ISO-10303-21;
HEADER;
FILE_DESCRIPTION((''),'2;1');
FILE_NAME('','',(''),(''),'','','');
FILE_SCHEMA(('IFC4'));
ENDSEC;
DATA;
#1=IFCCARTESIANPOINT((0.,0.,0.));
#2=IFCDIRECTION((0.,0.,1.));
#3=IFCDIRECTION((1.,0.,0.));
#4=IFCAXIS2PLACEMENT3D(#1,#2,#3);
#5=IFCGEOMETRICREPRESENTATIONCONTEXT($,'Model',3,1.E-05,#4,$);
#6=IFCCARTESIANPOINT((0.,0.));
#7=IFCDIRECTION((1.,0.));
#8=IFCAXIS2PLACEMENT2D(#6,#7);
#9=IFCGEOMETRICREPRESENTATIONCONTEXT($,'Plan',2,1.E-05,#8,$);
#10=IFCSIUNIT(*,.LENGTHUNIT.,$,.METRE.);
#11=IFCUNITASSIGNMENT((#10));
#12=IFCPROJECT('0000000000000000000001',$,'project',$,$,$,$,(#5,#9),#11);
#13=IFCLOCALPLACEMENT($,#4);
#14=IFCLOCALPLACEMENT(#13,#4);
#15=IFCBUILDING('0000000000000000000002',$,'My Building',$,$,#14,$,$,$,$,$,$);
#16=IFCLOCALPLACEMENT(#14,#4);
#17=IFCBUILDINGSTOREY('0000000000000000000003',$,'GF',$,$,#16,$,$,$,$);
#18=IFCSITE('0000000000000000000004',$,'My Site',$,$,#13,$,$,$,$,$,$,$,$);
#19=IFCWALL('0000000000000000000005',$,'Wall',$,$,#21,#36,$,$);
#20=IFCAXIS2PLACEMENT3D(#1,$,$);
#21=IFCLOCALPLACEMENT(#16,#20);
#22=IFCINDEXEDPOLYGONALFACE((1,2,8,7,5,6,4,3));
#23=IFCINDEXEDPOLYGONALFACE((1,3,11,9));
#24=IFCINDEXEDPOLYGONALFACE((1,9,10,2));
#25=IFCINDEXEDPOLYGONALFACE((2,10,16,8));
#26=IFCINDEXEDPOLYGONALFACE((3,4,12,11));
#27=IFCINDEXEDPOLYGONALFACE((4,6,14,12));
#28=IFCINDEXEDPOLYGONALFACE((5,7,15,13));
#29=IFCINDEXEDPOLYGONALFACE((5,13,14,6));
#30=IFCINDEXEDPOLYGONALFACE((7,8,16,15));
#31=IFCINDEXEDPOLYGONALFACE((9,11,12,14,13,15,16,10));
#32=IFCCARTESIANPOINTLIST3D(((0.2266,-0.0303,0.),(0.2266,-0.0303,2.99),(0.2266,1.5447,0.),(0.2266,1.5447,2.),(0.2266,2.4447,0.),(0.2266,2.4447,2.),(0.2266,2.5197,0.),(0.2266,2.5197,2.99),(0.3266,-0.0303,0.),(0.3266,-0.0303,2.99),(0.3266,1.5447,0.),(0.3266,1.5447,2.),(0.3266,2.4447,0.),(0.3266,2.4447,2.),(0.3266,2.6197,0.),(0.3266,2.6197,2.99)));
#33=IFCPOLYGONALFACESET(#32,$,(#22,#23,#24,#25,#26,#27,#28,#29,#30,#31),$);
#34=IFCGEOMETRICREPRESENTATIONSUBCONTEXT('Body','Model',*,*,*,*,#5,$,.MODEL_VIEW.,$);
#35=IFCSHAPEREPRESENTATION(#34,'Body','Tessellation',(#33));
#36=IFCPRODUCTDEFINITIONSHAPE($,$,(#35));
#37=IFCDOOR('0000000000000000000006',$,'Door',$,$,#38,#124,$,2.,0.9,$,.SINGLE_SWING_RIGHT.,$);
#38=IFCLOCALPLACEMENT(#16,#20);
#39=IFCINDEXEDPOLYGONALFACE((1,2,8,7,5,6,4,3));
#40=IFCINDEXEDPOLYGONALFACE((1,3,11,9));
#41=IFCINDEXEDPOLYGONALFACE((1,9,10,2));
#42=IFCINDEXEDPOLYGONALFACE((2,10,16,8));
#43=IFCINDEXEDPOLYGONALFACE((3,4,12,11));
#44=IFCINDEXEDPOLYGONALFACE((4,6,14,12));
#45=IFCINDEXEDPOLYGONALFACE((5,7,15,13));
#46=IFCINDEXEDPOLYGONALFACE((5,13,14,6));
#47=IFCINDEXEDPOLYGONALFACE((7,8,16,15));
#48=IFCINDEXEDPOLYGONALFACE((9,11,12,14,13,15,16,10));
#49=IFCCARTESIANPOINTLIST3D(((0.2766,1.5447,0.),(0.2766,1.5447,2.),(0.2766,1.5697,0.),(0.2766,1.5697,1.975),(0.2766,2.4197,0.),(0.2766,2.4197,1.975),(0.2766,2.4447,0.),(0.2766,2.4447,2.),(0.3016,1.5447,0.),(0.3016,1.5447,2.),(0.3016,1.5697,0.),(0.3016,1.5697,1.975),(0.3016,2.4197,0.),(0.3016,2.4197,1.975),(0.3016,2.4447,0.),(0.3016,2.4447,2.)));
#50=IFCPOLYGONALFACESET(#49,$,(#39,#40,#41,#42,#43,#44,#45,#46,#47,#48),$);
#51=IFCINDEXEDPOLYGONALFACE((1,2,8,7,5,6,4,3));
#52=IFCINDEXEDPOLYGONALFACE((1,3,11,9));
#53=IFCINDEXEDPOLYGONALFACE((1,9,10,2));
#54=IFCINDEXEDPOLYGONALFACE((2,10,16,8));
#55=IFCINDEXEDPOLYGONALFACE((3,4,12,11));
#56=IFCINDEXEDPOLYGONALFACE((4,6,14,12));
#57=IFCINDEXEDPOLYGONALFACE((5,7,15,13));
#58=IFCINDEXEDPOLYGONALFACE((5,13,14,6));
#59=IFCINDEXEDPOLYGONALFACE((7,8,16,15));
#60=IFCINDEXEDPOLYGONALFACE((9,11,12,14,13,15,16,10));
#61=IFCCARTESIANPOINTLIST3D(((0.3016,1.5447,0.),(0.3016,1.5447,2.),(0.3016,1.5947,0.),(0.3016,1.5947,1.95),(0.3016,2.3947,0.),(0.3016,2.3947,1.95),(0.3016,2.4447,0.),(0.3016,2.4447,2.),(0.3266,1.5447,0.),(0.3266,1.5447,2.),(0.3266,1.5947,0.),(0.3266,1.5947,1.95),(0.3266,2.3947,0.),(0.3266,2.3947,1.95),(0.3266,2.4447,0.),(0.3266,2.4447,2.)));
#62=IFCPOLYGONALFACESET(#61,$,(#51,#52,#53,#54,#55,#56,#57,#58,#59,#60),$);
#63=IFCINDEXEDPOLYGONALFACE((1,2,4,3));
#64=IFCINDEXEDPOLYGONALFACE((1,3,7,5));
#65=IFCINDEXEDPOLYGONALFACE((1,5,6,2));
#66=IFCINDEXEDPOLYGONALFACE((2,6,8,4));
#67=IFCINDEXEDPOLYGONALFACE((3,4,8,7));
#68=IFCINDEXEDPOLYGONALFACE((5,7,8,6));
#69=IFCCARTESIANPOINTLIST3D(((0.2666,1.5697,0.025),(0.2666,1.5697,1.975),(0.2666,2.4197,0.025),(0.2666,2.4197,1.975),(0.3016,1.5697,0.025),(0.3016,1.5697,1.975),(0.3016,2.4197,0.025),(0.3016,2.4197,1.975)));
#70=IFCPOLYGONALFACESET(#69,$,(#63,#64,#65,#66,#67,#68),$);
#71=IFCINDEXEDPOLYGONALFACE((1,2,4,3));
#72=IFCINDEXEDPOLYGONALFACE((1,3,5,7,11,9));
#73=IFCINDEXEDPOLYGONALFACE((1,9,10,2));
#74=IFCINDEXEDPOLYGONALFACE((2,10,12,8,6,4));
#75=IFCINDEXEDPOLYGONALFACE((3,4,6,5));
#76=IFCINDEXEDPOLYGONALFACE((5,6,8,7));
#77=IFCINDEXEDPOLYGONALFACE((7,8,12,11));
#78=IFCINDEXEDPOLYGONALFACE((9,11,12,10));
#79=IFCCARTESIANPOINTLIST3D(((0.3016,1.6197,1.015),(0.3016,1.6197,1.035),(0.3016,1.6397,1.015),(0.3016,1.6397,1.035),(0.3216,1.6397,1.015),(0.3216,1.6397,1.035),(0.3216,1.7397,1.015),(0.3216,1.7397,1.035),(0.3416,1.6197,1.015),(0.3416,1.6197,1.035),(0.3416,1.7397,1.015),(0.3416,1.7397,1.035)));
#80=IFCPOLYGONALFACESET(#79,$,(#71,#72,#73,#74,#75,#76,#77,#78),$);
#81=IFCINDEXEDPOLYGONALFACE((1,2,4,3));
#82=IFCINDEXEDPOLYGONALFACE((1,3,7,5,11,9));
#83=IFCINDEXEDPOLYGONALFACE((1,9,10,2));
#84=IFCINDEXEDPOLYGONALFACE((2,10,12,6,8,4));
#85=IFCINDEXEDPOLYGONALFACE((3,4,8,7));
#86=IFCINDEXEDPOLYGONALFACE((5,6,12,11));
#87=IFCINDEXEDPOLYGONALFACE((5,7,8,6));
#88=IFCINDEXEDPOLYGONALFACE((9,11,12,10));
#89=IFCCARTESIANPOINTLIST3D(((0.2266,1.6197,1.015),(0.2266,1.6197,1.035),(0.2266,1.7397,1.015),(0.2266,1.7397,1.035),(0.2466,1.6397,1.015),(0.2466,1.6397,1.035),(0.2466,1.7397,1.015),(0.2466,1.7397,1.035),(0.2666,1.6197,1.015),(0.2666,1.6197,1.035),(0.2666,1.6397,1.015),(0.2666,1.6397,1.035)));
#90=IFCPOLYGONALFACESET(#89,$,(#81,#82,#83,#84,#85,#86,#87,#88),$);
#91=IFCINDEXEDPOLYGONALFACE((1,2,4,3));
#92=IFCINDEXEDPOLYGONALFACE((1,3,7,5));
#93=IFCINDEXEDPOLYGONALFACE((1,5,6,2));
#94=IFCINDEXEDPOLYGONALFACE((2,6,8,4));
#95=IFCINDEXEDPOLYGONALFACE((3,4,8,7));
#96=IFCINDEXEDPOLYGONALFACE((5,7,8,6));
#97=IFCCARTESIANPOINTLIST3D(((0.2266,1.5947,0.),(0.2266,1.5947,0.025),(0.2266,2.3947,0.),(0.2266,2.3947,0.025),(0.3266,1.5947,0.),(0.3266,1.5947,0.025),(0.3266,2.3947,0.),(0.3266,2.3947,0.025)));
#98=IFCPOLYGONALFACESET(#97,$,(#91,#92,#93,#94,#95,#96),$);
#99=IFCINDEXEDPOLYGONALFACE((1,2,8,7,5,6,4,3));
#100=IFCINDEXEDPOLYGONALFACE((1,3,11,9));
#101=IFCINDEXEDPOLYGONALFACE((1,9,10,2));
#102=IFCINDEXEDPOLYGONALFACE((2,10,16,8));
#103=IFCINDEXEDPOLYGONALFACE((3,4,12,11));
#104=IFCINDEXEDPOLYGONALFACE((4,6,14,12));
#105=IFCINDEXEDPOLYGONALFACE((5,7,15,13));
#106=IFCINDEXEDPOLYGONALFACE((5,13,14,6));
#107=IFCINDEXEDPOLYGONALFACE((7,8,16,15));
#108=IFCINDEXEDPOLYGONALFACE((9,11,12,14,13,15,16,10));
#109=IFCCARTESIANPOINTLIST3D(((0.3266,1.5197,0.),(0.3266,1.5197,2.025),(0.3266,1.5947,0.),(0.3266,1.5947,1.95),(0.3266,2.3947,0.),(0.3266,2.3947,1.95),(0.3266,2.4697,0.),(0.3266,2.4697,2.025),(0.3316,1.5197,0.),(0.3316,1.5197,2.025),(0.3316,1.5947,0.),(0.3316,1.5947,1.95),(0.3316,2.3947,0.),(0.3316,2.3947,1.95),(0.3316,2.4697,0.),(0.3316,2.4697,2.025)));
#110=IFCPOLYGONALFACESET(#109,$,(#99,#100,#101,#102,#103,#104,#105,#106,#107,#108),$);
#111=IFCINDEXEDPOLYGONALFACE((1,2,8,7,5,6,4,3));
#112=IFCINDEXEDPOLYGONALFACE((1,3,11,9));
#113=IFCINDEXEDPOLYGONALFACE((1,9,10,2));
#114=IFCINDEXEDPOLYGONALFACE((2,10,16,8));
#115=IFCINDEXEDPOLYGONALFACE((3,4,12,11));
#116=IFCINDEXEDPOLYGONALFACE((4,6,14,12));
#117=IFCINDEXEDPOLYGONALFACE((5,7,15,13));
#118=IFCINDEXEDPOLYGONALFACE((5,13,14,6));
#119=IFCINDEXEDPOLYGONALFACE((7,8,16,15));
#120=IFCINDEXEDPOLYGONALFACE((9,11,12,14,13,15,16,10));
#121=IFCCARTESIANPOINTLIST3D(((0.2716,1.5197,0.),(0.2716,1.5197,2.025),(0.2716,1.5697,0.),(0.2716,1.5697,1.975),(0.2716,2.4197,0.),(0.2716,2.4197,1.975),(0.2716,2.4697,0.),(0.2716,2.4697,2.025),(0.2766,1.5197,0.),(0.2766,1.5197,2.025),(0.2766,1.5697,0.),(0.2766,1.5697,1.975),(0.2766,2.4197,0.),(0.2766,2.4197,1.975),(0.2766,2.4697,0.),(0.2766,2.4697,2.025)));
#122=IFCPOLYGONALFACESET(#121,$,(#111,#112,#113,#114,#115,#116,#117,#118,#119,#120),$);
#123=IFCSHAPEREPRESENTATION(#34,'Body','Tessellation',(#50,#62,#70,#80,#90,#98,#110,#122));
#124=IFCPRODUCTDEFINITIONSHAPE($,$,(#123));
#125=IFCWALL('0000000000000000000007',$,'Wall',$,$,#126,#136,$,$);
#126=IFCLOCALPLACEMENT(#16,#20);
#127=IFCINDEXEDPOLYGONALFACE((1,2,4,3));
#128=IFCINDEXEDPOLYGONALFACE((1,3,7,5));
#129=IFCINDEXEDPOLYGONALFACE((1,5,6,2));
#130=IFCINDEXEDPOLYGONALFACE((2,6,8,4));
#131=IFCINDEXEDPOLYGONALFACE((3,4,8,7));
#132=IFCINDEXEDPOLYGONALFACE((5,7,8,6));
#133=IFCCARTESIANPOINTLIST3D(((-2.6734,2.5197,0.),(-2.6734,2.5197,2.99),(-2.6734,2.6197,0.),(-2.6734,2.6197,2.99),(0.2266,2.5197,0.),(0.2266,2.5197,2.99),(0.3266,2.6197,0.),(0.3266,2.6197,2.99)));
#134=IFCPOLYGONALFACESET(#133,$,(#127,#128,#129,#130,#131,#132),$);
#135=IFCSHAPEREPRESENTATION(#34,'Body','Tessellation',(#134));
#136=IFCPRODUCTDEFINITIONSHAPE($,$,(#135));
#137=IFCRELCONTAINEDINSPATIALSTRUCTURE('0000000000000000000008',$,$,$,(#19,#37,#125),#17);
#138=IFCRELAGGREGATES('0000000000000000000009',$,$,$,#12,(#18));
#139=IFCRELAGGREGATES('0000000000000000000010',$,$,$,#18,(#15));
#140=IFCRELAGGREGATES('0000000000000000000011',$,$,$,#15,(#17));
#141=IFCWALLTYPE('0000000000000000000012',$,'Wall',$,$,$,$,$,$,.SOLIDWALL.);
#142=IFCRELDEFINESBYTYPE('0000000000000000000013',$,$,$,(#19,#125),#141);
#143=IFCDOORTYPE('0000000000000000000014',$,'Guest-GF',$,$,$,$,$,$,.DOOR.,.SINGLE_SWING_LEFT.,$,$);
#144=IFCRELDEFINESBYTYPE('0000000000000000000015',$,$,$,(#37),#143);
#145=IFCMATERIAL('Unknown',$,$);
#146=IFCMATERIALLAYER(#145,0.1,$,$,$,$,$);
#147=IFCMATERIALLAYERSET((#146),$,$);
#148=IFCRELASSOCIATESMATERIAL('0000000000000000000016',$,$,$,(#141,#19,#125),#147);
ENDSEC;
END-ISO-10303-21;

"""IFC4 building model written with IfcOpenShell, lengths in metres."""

from ifc_helpers import new_model, entity, si_unit, frame, origin_with_axes, origin_2d_with_axis, place, context, subcontext, project, spatial, line, indexed_curve, outline, extrude, shape, source, transform, mapped, material, layer, layer_set, layer_usage, type_object, type_shapes, element, fill, save


model = new_model("IFC4")

# Units and contexts
model_context = context("Model", 3, precision=1e-05, world=origin_with_axes())
plan_context = context("Plan", 2, precision=1e-05, world=origin_2d_with_axis())
body_context_1 = subcontext(model_context, "Body", "Model", "MODEL_VIEW")
body_context_2 = subcontext(plan_context, "Body", "Plan", "PLAN_VIEW")
ifc_project = project(units=[si_unit("LENGTHUNIT", "METRE")], contexts=[model_context, plan_context])

# Site, building, storey
site_placement = place(None, origin_with_axes())
site = spatial("IfcSite", under=ifc_project, at=site_placement, Name="My Site")
building_placement = place(site_placement, origin_with_axes())
building = spatial("IfcBuilding", under=site, at=building_placement, Name="My Building")
storey_placement = place(building_placement, origin_with_axes())
storey = spatial("IfcBuildingStorey", under=building, at=storey_placement, Name="GF")

# Shared definitions
ifc_material_1 = material(Name="Unknown")

# Shared definitions
ifc_layer_1 = layer(ifc_material_1, 0.1)
ifc_layer_set_1 = layer_set([ifc_layer_1])
wall_type = type_object("IfcWallType", Name="Wall", PredefinedType="SOLIDWALL", material=ifc_layer_set_1)

# Wall, opening, door
ifc_layer_usage_1 = layer_usage(ifc_layer_set_1, "AXIS2", "POSITIVE", 0.0)
wall_1_placement = place(storey_placement, frame((0.3266, -0.0303, 0.0), z_axis=(0.0, 0.0, 1.0), x_axis=(0.0, 1.0, 0.0)))
wall_1 = element("IfcWall", 1, at=wall_1_placement, inside=storey, type_object=wall_type, material=ifc_layer_usage_1, Name="Wall", context=body_context_1, shape_type="SweptSolid", body=[
    extrude(outline(indexed_curve([(0.0, 0.0), (0.0, 0.1), (2.55, 0.1), (2.65, 0.0)], segments=[line(1, 2, 3, 4, 1)])), origin_with_axes(), (0.0, 0.0, 1.0), 2.99),
])
shared_shape_1 = source(origin_with_axes(), body_context_1, "Body", "SweptSolid", [
    extrude(outline(indexed_curve([(0.0, 0.0), (0.9, 0.0), (0.9, 2.0), (0.0, 2.0)], segments=[line(1, 2, 3, 4, 1)])), frame((0.0, -0.6, 0.0), z_axis=(0.0, -1.0, 0.0), x_axis=(1.0, 0.0, 0.0)), (0.0, 0.0, -1.0), 1.2),
])
opening_1_placement = place(wall_1_placement, frame((1.575, 0.0, 0.0), z_axis=(0.0, 0.0, 1.0), x_axis=(1.0, 0.0, 0.0)))
opening_1 = element("IfcOpeningElement", 2, at=opening_1_placement, cuts=wall_1, PredefinedType="OPENING", context=body_context_1, shape_type="MappedRepresentation", body=[
    mapped(shared_shape_1, transform((0.0, 0.0, 0.0), x_axis=(1.0, 0.0, 0.0), y_axis=(0.0, 1.0, 0.0), z_axis=(0.0, 0.0, 1.0), scale=1.0)),
])
door_type_1 = type_object("IfcDoorType", Name="Guest-GF", OperationType="SINGLE_SWING_LEFT", PredefinedType="DOOR")
shared_shape_2 = source(origin_with_axes(), body_context_1, "Body", "SweptSolid", [
    extrude(outline(indexed_curve([(0.0, 0.0), (0.0, 2.0), (0.9, 2.0), (0.9, 0.0), (0.875, 0.0), (0.875, 1.975), (0.025, 1.975), (0.025, 0.0)], segments=[line(1, 2, 3, 4, 5, 6, 7, 8, 1)])), frame((0.0, 0.025, 0.0), z_axis=(0.0, -1.0, 0.0), x_axis=(1.0, 0.0, 0.0)), (0.0, 0.0, -1.0), 0.025),
    extrude(outline(indexed_curve([(0.0, 0.0), (0.0, 2.0), (0.9, 2.0), (0.9, 0.0), (0.85, 0.0), (0.85, 1.95), (0.05, 1.95), (0.05, 0.0)], segments=[line(1, 2, 3, 4, 5, 6, 7, 8, 1)])), frame((0.0, 0.0, 0.0), z_axis=(0.0, -1.0, 0.0), x_axis=(1.0, 0.0, 0.0)), (0.0, 0.0, -1.0), 0.025),
    extrude(outline(indexed_curve([(0.0, 0.0), (0.85, 0.0), (0.85, 0.035), (0.0, 0.035)], segments=[line(1, 2, 3, 4, 1)])), frame((0.025, 0.025, 0.025), z_axis=(0.0, 0.0, 1.0), x_axis=(1.0, 0.0, 0.0)), (0.0, 0.0, 1.0), 1.95),
    extrude(outline(indexed_curve([(0.0, 0.0), (0.0, -0.04), (0.12, -0.04), (0.12, -0.02), (0.02, -0.02), (0.02, 0.0)], segments=[line(1, 2, 3, 4, 5, 6, 1)])), frame((0.075, 0.025, 1.015), z_axis=(0.0, 0.0, 1.0), x_axis=(1.0, 0.0, 0.0)), (0.0, 0.0, 1.0), 0.02),
    extrude(outline(indexed_curve([(0.0, 0.0), (0.0, 0.04), (0.12, 0.04), (0.12, 0.02), (0.02, 0.02), (0.02, 0.0)], segments=[line(1, 2, 3, 4, 5, 6, 1)])), frame((0.075, 0.06, 1.015), z_axis=(0.0, 0.0, 1.0), x_axis=(1.0, 0.0, 0.0)), (0.0, 0.0, 1.0), 0.02),
    extrude(outline(indexed_curve([(0.0, 0.0), (0.8, 0.0), (0.8, 0.1), (0.0, 0.1)], segments=[line(1, 2, 3, 4, 1)])), frame((0.05, 0.0, 0.0), z_axis=(0.0, 0.0, 1.0), x_axis=(1.0, 0.0, 0.0)), (0.0, 0.0, 1.0), 0.025),
    extrude(outline(indexed_curve([(0.0, 0.0), (0.0, 2.025), (0.95, 2.025), (0.95, 0.0), (0.875, 0.0), (0.875, 1.95), (0.075, 1.95), (0.075, 0.0)], segments=[line(1, 2, 3, 4, 5, 6, 7, 8, 1)])), frame((-0.025, -0.005, 0.0), z_axis=(0.0, -1.0, 0.0), x_axis=(1.0, 0.0, 0.0)), (0.0, 0.0, -1.0), 0.005),
    extrude(outline(indexed_curve([(0.0, 0.0), (0.0, 2.025), (0.95, 2.025), (0.95, 0.0), (0.9, 0.0), (0.9, 1.975), (0.05, 1.975), (0.05, 0.0)], segments=[line(1, 2, 3, 4, 5, 6, 7, 8, 1)])), frame((-0.025, 0.05, 0.0), z_axis=(0.0, -1.0, 0.0), x_axis=(1.0, 0.0, 0.0)), (0.0, 0.0, -1.0), 0.005),
])
shared_shape_3 = source(origin_with_axes(), body_context_2, "Body", "Curve2D", [
    entity("IfcIndexedPolyCurve", entity("IfcCartesianPointList2D", [[0.0, 0.0], [0.0, 0.05], [0.025, 0.05], [0.025, 0.025], [0.05, 0.025], [0.05, 0.0]]), [entity("IfcLineIndex", [1, 2, 3, 4, 5, 6, 1])]),
    entity("IfcIndexedPolyCurve", entity("IfcCartesianPointList2D", [[0.9, 0.0], [0.9, 0.05], [0.875, 0.05], [0.875, 0.025], [0.85, 0.025], [0.85, 0.0]]), [entity("IfcLineIndex", [1, 2, 3, 4, 5, 6, 1])]),
    entity("IfcTrimmedCurve", entity("IfcEllipse", entity("IfcAxis2Placement2D", entity("IfcCartesianPoint", [0.84, 0.05]), entity("IfcDirection", [1.0, 0.0])), 0.815, 0.85), [entity("IfcCartesianPoint", [0.84, 0.9])], [entity("IfcCartesianPoint", [0.025, 0.05])], True, "CARTESIAN"),
    entity("IfcIndexedPolyCurve", entity("IfcCartesianPointList2D", [[0.875, 0.05], [0.84, 0.05], [0.84, 0.9], [0.875, 0.9]]), [entity("IfcLineIndex", [1, 2, 3, 4, 1])]),
])
type_shapes(door_type_1, [shared_shape_2, shared_shape_3])
door_1_placement = place(opening_1_placement, frame((0.0, 0.0, 0.0), z_axis=(0.0, 0.0, 1.0), x_axis=(1.0, 0.0, 0.0)))
door_1 = element("IfcDoor", 3, at=door_1_placement, inside=storey, type_object=door_type_1, Name="Door", OperationType="SINGLE_SWING_RIGHT", OverallHeight=2.0, OverallWidth=0.9, shapes=[
    shape(body_context_1, "Body", "MappedRepresentation", [mapped(shared_shape_2, transform((0.0, 0.0, 0.0), x_axis=(1.0, 0.0, 0.0), y_axis=(0.0, 1.0, 0.0), z_axis=(0.0, 0.0, 1.0), scale=1.0))]),
    shape(body_context_2, "Body", "MappedRepresentation", [mapped(shared_shape_3, transform((0.0, 0.0, 0.0), x_axis=(1.0, 0.0, 0.0), y_axis=(0.0, 1.0, 0.0), z_axis=(0.0, 0.0, 1.0), scale=1.0))]),
])
fill(opening_1, door_1)

# Wall
ifc_layer_usage_2 = layer_usage(ifc_layer_set_1, "AXIS2", "POSITIVE", 0.0)
wall_2_placement = place(storey_placement, frame((0.3266, 2.6197, 0.0), z_axis=(0.0, 0.0, 1.0), x_axis=(-1.0, 0.0, 0.0)))
element("IfcWall", 4, at=wall_2_placement, inside=storey, type_object=wall_type, material=ifc_layer_usage_2, Name="Wall", context=body_context_1, shape_type="SweptSolid", body=[
    extrude(outline(indexed_curve([(0.0, 0.0), (0.1, 0.1), (3.0, 0.1), (3.0, 0.0)], segments=[line(1, 2, 3, 4, 1)])), origin_with_axes(), (0.0, 0.0, 1.0), 2.99),
])

save(model, "model.ifc")
